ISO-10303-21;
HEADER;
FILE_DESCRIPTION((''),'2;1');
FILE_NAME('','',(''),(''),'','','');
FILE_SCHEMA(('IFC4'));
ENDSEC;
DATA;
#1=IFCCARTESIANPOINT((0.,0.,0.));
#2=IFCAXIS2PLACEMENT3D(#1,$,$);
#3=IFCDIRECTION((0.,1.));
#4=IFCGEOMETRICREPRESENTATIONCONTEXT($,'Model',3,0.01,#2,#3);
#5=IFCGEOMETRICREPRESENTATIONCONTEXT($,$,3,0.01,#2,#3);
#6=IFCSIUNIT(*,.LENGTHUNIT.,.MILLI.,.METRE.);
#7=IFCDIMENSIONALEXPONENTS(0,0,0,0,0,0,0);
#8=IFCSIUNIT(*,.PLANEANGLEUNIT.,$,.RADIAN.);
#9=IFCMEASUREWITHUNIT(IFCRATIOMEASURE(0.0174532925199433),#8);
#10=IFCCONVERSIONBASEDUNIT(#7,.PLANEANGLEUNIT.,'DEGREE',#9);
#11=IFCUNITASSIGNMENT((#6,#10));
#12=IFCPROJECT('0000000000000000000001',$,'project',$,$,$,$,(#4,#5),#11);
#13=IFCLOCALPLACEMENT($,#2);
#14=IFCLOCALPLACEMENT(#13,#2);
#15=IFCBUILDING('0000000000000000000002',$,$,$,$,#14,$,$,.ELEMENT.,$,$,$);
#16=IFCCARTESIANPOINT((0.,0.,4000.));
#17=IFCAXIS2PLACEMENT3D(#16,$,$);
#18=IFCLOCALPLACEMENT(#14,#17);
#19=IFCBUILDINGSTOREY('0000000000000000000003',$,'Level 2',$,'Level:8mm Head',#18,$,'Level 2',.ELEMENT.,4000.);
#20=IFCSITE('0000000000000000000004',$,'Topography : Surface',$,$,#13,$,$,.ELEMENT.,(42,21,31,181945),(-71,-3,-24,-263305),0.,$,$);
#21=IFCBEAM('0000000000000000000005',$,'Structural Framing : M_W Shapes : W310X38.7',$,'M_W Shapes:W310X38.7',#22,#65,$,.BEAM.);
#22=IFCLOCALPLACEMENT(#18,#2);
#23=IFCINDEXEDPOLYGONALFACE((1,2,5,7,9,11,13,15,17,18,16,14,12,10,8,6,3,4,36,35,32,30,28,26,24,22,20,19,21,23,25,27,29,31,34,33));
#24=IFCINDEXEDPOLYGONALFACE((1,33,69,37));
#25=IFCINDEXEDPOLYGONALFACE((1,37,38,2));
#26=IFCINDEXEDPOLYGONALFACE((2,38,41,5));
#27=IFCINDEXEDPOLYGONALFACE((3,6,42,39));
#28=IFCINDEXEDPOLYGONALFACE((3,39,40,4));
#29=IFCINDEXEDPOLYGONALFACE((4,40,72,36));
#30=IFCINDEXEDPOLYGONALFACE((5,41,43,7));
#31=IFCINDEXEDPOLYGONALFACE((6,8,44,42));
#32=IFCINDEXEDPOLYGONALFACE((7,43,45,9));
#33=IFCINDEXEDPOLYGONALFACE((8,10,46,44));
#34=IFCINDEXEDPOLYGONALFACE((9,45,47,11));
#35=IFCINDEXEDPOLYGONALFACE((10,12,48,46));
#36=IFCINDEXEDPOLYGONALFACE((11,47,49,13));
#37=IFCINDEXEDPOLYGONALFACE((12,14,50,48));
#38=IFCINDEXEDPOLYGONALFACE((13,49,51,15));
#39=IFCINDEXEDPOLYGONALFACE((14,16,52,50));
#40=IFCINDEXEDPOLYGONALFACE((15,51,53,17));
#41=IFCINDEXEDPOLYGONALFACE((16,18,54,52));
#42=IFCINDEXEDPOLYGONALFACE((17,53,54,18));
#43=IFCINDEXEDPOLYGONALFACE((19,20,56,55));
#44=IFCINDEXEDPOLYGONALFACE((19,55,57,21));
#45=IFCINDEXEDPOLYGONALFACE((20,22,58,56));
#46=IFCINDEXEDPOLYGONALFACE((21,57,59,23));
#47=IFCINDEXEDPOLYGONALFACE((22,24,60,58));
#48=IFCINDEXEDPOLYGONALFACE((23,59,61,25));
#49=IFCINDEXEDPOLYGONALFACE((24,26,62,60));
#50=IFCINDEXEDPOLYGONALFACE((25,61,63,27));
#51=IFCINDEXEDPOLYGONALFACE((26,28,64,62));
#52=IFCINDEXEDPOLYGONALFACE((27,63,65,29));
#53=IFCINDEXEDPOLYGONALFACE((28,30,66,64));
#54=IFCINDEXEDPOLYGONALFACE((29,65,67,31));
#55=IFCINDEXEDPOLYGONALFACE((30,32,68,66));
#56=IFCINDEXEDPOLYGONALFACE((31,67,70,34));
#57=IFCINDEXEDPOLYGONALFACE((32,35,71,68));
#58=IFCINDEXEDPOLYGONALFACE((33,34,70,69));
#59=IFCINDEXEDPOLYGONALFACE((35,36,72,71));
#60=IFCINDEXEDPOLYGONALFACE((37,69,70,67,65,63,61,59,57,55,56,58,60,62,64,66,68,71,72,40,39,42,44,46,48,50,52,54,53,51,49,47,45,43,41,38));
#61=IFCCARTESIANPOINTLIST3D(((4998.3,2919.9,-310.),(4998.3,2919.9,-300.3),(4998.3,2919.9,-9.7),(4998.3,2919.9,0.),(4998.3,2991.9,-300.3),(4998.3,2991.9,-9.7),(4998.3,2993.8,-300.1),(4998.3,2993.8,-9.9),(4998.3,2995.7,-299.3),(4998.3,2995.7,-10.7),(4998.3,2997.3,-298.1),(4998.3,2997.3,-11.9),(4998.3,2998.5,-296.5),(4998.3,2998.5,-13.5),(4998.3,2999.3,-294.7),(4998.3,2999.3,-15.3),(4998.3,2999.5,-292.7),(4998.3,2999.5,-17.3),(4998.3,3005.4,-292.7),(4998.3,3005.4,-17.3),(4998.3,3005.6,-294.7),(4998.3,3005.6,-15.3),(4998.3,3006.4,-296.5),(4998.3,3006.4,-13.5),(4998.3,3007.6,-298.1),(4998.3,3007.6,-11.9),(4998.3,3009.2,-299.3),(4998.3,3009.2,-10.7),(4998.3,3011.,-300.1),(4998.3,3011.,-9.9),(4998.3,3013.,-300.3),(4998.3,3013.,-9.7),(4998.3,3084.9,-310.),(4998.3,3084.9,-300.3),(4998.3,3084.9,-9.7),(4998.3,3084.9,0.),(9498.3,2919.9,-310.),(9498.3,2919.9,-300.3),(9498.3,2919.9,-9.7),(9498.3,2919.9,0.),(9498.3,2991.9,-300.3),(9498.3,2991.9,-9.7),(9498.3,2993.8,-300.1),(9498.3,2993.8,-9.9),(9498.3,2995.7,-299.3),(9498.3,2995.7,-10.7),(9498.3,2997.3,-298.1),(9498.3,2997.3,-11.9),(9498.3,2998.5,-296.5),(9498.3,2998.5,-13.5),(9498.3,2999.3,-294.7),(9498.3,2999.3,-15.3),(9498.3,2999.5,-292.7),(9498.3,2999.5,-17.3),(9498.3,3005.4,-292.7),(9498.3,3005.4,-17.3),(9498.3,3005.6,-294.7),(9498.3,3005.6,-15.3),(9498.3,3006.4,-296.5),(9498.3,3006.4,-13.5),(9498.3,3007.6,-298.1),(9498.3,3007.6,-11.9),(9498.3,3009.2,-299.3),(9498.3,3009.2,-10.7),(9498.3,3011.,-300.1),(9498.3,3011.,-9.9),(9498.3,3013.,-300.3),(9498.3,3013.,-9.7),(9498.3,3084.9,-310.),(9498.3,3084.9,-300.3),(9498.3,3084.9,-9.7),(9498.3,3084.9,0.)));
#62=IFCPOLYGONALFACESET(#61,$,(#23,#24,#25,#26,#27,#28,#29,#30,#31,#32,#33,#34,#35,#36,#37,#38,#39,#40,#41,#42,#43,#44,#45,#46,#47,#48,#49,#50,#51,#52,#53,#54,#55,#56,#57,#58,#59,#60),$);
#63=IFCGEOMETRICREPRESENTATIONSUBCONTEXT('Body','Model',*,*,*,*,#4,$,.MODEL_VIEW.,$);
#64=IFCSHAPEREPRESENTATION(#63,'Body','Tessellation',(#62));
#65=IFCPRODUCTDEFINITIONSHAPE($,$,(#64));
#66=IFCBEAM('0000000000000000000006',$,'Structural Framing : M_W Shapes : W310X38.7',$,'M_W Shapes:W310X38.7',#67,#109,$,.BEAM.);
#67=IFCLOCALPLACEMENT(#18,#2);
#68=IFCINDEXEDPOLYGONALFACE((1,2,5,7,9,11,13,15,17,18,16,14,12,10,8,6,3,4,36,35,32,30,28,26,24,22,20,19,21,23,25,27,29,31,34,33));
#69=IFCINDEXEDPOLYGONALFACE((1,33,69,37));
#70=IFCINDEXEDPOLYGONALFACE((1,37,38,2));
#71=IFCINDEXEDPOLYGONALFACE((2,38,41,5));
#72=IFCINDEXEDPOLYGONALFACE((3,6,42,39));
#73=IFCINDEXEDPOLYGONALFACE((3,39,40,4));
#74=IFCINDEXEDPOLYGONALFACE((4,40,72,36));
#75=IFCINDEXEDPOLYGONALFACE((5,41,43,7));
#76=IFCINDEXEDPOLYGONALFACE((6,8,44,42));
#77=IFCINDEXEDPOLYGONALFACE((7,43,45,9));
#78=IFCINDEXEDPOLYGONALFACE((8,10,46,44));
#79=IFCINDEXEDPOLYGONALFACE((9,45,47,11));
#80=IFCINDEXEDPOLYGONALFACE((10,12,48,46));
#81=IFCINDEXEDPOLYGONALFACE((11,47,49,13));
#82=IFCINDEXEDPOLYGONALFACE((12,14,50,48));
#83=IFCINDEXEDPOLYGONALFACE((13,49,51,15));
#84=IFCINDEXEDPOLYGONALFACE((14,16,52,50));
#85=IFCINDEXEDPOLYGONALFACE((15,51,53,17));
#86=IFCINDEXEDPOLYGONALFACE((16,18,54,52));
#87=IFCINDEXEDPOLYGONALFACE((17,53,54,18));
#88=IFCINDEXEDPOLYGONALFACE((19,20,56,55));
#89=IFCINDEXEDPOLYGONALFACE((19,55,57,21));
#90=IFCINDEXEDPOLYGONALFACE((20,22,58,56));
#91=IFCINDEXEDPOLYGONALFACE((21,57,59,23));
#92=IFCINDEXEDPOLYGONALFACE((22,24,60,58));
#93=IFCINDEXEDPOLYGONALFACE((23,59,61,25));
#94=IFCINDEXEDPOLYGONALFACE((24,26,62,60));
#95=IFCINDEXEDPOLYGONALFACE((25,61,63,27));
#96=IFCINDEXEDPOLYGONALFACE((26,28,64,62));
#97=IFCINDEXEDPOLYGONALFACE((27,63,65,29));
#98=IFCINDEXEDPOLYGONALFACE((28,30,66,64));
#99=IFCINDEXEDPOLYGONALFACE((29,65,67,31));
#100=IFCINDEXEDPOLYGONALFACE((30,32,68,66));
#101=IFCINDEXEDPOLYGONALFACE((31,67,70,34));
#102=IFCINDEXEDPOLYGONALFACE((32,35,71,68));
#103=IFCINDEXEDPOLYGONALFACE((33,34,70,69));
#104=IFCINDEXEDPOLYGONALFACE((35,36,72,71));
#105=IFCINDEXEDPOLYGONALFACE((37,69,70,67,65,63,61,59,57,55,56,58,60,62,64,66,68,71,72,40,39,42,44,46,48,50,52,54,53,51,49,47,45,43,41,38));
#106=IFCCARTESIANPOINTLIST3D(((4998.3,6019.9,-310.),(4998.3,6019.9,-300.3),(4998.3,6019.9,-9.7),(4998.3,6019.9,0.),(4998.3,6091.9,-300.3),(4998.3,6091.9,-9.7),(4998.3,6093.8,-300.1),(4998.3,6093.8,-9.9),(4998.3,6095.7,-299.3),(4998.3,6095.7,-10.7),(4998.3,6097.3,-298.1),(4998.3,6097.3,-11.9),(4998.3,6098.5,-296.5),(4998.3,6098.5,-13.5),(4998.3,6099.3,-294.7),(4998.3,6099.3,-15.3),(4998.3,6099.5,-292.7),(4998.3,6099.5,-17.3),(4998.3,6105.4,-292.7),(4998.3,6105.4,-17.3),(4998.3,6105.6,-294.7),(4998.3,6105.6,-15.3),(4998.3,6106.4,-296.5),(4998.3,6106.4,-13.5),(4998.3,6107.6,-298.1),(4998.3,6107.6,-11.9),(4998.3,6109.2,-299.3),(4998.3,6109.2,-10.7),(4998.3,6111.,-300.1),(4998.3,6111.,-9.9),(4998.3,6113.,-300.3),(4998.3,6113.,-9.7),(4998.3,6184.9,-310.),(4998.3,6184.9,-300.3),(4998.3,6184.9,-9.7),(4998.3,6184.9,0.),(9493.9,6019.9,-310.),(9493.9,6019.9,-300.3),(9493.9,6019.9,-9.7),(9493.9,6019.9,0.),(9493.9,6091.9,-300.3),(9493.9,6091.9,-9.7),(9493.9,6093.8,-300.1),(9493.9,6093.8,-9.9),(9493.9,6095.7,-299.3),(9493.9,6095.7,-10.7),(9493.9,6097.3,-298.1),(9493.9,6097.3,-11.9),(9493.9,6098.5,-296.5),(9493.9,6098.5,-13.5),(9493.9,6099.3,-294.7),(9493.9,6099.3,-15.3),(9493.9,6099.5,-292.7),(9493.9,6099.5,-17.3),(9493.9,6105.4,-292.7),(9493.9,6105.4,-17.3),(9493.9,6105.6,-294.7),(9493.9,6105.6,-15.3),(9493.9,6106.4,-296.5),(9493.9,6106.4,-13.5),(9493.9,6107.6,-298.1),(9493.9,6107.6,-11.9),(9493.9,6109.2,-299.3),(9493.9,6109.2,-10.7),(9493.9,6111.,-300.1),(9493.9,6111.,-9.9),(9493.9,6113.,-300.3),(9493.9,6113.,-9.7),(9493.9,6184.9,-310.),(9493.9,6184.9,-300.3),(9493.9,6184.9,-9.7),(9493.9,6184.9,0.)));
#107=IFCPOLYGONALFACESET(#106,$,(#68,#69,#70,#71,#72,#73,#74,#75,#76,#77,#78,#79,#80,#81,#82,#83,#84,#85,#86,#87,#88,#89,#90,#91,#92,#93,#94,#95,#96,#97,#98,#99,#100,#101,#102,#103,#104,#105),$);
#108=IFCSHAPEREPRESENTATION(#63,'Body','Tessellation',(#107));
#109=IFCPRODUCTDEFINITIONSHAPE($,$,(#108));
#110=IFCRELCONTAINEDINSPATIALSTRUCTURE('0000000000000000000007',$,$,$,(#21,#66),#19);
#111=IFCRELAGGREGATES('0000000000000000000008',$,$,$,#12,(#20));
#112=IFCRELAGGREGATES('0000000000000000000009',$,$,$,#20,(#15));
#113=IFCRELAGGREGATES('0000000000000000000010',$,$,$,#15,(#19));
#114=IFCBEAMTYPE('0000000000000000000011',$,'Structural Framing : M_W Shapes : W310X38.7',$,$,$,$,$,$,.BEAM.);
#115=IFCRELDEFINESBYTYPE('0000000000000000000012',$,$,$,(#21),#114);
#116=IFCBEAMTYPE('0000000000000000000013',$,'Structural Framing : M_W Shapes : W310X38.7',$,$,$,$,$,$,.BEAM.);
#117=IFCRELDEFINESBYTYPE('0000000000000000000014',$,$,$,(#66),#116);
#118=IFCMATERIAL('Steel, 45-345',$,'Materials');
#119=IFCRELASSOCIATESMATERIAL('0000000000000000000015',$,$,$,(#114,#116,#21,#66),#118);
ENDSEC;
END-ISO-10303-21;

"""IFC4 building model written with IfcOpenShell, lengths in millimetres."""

from ifc_helpers import new_model, entity, si_unit, converted_unit, direction, frame, frame_2d, origin, place, context, subcontext, project, spatial, i_section, extrude, source, transform, mapped, material, material_profile, profile_set, profile_usage, type_object, type_shapes, element, save


model = new_model("IFC4")

# Units and contexts
model_context = context("Model", 3, precision=0.01, world=origin(), true_north=direction((0.0, 1.0)))
context_of_model = context(None, 3, precision=0.01, world=origin(), true_north=direction((0.0, 1.0)))
body_context = subcontext(model_context, "Body", "Model", "MODEL_VIEW")
ifc_project = project(units=[si_unit("LENGTHUNIT", "METRE", prefix="MILLI"), converted_unit("PLANEANGLEUNIT", "DEGREE", entity("IfcRatioMeasure", 0.0174532925199433), si_unit("PLANEANGLEUNIT", "RADIAN"), dimensions=[0, 0, 0, 0, 0, 0, 0])], contexts=[model_context, context_of_model])

# Site, building, storey
site_placement = place(None, origin())
site = spatial("IfcSite", under=ifc_project, at=site_placement, Name="Topography : Surface", CompositionType="ELEMENT", RefLatitude=(42, 21, 31, 181945), RefLongitude=(-71, -3, -24, -263305), RefElevation=0.0)
building_placement = place(site_placement, origin())
building = spatial("IfcBuilding", under=site, at=building_placement, CompositionType="ELEMENT")
storey_placement = place(building_placement, frame((0.0, 0.0, 4000.0)))
storey = spatial("IfcBuildingStorey", under=building, at=storey_placement, Name="Level 2", ObjectType="Level:8mm Head", LongName="Level 2", CompositionType="ELEMENT", Elevation=4000.0)

# Beams
ifc_material = material(Name="Steel, 45-345", Category="Materials")
ifc_material_profile = material_profile(ifc_material, i_section(OverallWidth=165.0, OverallDepth=310.0, WebThickness=5.8, FlangeThickness=9.7, FilletRadius=7.7, at=frame_2d((0.0, 0.0), x_axis=(0.0, 1.0))), Name="W310X38.7")
ifc_profile_set = profile_set([ifc_material_profile], Name="W310X38.7")
ifc_profile_usage_1 = profile_usage(ifc_profile_set, cardinal=8)
beam_type_1 = type_object("IfcBeamType", Name="Structural Framing : M_W Shapes : W310X38.7", PredefinedType="BEAM", material=ifc_profile_set)
shared_shape_1 = source(origin(), body_context, "Body", "SweptSolid", [
    extrude(i_section(OverallWidth=165.0, OverallDepth=310.0, WebThickness=5.8, FlangeThickness=9.7, FilletRadius=7.7, at=frame_2d((0.0, 0.0), x_axis=(0.0, 1.0))), frame((-2250.0, 0.0, 0.0), z_axis=(1.0, 0.0, 0.0), x_axis=(0.0, 0.0, -1.0)), (0.0, 0.0, 1.0), 4500.0),
])
type_shapes(beam_type_1, [shared_shape_1])
beam_1_placement = place(storey_placement, frame((7248.3, 3002.4, -155.0)))
element("IfcBeam", 1, at=beam_1_placement, inside=storey, type_object=beam_type_1, material=ifc_profile_usage_1, Name="Structural Framing : M_W Shapes : W310X38.7", ObjectType="M_W Shapes:W310X38.7", PredefinedType="BEAM", context=body_context, shape_type="MappedRepresentation", body=[
    mapped(shared_shape_1, transform((0.0, 0.0, 0.0), scale=1.0)),
])
ifc_profile_usage_2 = profile_usage(ifc_profile_set, cardinal=8)
beam_type_2 = type_object("IfcBeamType", Name="Structural Framing : M_W Shapes : W310X38.7", PredefinedType="BEAM", material=ifc_profile_set)
shared_shape_2 = source(origin(), body_context, "Body", "SweptSolid", [
    extrude(i_section(OverallWidth=165.0, OverallDepth=310.0, WebThickness=5.8, FlangeThickness=9.7, FilletRadius=7.7, at=frame_2d((0.0, 0.0), x_axis=(0.0, 1.0))), frame((-2250.0, 0.0, 0.0), z_axis=(1.0, 0.0, 0.0), x_axis=(0.0, 0.0, -1.0)), (0.0, 0.0, 1.0), 4495.6),
])
type_shapes(beam_type_2, [shared_shape_2])
beam_2_placement = place(storey_placement, frame((7248.3, 6102.4, -155.0)))
element("IfcBeam", 2, at=beam_2_placement, inside=storey, type_object=beam_type_2, material=ifc_profile_usage_2, Name="Structural Framing : M_W Shapes : W310X38.7", ObjectType="M_W Shapes:W310X38.7", PredefinedType="BEAM", context=body_context, shape_type="MappedRepresentation", body=[
    mapped(shared_shape_2, transform((0.0, 0.0, 0.0), scale=1.0)),
])

save(model, "model.ifc")
